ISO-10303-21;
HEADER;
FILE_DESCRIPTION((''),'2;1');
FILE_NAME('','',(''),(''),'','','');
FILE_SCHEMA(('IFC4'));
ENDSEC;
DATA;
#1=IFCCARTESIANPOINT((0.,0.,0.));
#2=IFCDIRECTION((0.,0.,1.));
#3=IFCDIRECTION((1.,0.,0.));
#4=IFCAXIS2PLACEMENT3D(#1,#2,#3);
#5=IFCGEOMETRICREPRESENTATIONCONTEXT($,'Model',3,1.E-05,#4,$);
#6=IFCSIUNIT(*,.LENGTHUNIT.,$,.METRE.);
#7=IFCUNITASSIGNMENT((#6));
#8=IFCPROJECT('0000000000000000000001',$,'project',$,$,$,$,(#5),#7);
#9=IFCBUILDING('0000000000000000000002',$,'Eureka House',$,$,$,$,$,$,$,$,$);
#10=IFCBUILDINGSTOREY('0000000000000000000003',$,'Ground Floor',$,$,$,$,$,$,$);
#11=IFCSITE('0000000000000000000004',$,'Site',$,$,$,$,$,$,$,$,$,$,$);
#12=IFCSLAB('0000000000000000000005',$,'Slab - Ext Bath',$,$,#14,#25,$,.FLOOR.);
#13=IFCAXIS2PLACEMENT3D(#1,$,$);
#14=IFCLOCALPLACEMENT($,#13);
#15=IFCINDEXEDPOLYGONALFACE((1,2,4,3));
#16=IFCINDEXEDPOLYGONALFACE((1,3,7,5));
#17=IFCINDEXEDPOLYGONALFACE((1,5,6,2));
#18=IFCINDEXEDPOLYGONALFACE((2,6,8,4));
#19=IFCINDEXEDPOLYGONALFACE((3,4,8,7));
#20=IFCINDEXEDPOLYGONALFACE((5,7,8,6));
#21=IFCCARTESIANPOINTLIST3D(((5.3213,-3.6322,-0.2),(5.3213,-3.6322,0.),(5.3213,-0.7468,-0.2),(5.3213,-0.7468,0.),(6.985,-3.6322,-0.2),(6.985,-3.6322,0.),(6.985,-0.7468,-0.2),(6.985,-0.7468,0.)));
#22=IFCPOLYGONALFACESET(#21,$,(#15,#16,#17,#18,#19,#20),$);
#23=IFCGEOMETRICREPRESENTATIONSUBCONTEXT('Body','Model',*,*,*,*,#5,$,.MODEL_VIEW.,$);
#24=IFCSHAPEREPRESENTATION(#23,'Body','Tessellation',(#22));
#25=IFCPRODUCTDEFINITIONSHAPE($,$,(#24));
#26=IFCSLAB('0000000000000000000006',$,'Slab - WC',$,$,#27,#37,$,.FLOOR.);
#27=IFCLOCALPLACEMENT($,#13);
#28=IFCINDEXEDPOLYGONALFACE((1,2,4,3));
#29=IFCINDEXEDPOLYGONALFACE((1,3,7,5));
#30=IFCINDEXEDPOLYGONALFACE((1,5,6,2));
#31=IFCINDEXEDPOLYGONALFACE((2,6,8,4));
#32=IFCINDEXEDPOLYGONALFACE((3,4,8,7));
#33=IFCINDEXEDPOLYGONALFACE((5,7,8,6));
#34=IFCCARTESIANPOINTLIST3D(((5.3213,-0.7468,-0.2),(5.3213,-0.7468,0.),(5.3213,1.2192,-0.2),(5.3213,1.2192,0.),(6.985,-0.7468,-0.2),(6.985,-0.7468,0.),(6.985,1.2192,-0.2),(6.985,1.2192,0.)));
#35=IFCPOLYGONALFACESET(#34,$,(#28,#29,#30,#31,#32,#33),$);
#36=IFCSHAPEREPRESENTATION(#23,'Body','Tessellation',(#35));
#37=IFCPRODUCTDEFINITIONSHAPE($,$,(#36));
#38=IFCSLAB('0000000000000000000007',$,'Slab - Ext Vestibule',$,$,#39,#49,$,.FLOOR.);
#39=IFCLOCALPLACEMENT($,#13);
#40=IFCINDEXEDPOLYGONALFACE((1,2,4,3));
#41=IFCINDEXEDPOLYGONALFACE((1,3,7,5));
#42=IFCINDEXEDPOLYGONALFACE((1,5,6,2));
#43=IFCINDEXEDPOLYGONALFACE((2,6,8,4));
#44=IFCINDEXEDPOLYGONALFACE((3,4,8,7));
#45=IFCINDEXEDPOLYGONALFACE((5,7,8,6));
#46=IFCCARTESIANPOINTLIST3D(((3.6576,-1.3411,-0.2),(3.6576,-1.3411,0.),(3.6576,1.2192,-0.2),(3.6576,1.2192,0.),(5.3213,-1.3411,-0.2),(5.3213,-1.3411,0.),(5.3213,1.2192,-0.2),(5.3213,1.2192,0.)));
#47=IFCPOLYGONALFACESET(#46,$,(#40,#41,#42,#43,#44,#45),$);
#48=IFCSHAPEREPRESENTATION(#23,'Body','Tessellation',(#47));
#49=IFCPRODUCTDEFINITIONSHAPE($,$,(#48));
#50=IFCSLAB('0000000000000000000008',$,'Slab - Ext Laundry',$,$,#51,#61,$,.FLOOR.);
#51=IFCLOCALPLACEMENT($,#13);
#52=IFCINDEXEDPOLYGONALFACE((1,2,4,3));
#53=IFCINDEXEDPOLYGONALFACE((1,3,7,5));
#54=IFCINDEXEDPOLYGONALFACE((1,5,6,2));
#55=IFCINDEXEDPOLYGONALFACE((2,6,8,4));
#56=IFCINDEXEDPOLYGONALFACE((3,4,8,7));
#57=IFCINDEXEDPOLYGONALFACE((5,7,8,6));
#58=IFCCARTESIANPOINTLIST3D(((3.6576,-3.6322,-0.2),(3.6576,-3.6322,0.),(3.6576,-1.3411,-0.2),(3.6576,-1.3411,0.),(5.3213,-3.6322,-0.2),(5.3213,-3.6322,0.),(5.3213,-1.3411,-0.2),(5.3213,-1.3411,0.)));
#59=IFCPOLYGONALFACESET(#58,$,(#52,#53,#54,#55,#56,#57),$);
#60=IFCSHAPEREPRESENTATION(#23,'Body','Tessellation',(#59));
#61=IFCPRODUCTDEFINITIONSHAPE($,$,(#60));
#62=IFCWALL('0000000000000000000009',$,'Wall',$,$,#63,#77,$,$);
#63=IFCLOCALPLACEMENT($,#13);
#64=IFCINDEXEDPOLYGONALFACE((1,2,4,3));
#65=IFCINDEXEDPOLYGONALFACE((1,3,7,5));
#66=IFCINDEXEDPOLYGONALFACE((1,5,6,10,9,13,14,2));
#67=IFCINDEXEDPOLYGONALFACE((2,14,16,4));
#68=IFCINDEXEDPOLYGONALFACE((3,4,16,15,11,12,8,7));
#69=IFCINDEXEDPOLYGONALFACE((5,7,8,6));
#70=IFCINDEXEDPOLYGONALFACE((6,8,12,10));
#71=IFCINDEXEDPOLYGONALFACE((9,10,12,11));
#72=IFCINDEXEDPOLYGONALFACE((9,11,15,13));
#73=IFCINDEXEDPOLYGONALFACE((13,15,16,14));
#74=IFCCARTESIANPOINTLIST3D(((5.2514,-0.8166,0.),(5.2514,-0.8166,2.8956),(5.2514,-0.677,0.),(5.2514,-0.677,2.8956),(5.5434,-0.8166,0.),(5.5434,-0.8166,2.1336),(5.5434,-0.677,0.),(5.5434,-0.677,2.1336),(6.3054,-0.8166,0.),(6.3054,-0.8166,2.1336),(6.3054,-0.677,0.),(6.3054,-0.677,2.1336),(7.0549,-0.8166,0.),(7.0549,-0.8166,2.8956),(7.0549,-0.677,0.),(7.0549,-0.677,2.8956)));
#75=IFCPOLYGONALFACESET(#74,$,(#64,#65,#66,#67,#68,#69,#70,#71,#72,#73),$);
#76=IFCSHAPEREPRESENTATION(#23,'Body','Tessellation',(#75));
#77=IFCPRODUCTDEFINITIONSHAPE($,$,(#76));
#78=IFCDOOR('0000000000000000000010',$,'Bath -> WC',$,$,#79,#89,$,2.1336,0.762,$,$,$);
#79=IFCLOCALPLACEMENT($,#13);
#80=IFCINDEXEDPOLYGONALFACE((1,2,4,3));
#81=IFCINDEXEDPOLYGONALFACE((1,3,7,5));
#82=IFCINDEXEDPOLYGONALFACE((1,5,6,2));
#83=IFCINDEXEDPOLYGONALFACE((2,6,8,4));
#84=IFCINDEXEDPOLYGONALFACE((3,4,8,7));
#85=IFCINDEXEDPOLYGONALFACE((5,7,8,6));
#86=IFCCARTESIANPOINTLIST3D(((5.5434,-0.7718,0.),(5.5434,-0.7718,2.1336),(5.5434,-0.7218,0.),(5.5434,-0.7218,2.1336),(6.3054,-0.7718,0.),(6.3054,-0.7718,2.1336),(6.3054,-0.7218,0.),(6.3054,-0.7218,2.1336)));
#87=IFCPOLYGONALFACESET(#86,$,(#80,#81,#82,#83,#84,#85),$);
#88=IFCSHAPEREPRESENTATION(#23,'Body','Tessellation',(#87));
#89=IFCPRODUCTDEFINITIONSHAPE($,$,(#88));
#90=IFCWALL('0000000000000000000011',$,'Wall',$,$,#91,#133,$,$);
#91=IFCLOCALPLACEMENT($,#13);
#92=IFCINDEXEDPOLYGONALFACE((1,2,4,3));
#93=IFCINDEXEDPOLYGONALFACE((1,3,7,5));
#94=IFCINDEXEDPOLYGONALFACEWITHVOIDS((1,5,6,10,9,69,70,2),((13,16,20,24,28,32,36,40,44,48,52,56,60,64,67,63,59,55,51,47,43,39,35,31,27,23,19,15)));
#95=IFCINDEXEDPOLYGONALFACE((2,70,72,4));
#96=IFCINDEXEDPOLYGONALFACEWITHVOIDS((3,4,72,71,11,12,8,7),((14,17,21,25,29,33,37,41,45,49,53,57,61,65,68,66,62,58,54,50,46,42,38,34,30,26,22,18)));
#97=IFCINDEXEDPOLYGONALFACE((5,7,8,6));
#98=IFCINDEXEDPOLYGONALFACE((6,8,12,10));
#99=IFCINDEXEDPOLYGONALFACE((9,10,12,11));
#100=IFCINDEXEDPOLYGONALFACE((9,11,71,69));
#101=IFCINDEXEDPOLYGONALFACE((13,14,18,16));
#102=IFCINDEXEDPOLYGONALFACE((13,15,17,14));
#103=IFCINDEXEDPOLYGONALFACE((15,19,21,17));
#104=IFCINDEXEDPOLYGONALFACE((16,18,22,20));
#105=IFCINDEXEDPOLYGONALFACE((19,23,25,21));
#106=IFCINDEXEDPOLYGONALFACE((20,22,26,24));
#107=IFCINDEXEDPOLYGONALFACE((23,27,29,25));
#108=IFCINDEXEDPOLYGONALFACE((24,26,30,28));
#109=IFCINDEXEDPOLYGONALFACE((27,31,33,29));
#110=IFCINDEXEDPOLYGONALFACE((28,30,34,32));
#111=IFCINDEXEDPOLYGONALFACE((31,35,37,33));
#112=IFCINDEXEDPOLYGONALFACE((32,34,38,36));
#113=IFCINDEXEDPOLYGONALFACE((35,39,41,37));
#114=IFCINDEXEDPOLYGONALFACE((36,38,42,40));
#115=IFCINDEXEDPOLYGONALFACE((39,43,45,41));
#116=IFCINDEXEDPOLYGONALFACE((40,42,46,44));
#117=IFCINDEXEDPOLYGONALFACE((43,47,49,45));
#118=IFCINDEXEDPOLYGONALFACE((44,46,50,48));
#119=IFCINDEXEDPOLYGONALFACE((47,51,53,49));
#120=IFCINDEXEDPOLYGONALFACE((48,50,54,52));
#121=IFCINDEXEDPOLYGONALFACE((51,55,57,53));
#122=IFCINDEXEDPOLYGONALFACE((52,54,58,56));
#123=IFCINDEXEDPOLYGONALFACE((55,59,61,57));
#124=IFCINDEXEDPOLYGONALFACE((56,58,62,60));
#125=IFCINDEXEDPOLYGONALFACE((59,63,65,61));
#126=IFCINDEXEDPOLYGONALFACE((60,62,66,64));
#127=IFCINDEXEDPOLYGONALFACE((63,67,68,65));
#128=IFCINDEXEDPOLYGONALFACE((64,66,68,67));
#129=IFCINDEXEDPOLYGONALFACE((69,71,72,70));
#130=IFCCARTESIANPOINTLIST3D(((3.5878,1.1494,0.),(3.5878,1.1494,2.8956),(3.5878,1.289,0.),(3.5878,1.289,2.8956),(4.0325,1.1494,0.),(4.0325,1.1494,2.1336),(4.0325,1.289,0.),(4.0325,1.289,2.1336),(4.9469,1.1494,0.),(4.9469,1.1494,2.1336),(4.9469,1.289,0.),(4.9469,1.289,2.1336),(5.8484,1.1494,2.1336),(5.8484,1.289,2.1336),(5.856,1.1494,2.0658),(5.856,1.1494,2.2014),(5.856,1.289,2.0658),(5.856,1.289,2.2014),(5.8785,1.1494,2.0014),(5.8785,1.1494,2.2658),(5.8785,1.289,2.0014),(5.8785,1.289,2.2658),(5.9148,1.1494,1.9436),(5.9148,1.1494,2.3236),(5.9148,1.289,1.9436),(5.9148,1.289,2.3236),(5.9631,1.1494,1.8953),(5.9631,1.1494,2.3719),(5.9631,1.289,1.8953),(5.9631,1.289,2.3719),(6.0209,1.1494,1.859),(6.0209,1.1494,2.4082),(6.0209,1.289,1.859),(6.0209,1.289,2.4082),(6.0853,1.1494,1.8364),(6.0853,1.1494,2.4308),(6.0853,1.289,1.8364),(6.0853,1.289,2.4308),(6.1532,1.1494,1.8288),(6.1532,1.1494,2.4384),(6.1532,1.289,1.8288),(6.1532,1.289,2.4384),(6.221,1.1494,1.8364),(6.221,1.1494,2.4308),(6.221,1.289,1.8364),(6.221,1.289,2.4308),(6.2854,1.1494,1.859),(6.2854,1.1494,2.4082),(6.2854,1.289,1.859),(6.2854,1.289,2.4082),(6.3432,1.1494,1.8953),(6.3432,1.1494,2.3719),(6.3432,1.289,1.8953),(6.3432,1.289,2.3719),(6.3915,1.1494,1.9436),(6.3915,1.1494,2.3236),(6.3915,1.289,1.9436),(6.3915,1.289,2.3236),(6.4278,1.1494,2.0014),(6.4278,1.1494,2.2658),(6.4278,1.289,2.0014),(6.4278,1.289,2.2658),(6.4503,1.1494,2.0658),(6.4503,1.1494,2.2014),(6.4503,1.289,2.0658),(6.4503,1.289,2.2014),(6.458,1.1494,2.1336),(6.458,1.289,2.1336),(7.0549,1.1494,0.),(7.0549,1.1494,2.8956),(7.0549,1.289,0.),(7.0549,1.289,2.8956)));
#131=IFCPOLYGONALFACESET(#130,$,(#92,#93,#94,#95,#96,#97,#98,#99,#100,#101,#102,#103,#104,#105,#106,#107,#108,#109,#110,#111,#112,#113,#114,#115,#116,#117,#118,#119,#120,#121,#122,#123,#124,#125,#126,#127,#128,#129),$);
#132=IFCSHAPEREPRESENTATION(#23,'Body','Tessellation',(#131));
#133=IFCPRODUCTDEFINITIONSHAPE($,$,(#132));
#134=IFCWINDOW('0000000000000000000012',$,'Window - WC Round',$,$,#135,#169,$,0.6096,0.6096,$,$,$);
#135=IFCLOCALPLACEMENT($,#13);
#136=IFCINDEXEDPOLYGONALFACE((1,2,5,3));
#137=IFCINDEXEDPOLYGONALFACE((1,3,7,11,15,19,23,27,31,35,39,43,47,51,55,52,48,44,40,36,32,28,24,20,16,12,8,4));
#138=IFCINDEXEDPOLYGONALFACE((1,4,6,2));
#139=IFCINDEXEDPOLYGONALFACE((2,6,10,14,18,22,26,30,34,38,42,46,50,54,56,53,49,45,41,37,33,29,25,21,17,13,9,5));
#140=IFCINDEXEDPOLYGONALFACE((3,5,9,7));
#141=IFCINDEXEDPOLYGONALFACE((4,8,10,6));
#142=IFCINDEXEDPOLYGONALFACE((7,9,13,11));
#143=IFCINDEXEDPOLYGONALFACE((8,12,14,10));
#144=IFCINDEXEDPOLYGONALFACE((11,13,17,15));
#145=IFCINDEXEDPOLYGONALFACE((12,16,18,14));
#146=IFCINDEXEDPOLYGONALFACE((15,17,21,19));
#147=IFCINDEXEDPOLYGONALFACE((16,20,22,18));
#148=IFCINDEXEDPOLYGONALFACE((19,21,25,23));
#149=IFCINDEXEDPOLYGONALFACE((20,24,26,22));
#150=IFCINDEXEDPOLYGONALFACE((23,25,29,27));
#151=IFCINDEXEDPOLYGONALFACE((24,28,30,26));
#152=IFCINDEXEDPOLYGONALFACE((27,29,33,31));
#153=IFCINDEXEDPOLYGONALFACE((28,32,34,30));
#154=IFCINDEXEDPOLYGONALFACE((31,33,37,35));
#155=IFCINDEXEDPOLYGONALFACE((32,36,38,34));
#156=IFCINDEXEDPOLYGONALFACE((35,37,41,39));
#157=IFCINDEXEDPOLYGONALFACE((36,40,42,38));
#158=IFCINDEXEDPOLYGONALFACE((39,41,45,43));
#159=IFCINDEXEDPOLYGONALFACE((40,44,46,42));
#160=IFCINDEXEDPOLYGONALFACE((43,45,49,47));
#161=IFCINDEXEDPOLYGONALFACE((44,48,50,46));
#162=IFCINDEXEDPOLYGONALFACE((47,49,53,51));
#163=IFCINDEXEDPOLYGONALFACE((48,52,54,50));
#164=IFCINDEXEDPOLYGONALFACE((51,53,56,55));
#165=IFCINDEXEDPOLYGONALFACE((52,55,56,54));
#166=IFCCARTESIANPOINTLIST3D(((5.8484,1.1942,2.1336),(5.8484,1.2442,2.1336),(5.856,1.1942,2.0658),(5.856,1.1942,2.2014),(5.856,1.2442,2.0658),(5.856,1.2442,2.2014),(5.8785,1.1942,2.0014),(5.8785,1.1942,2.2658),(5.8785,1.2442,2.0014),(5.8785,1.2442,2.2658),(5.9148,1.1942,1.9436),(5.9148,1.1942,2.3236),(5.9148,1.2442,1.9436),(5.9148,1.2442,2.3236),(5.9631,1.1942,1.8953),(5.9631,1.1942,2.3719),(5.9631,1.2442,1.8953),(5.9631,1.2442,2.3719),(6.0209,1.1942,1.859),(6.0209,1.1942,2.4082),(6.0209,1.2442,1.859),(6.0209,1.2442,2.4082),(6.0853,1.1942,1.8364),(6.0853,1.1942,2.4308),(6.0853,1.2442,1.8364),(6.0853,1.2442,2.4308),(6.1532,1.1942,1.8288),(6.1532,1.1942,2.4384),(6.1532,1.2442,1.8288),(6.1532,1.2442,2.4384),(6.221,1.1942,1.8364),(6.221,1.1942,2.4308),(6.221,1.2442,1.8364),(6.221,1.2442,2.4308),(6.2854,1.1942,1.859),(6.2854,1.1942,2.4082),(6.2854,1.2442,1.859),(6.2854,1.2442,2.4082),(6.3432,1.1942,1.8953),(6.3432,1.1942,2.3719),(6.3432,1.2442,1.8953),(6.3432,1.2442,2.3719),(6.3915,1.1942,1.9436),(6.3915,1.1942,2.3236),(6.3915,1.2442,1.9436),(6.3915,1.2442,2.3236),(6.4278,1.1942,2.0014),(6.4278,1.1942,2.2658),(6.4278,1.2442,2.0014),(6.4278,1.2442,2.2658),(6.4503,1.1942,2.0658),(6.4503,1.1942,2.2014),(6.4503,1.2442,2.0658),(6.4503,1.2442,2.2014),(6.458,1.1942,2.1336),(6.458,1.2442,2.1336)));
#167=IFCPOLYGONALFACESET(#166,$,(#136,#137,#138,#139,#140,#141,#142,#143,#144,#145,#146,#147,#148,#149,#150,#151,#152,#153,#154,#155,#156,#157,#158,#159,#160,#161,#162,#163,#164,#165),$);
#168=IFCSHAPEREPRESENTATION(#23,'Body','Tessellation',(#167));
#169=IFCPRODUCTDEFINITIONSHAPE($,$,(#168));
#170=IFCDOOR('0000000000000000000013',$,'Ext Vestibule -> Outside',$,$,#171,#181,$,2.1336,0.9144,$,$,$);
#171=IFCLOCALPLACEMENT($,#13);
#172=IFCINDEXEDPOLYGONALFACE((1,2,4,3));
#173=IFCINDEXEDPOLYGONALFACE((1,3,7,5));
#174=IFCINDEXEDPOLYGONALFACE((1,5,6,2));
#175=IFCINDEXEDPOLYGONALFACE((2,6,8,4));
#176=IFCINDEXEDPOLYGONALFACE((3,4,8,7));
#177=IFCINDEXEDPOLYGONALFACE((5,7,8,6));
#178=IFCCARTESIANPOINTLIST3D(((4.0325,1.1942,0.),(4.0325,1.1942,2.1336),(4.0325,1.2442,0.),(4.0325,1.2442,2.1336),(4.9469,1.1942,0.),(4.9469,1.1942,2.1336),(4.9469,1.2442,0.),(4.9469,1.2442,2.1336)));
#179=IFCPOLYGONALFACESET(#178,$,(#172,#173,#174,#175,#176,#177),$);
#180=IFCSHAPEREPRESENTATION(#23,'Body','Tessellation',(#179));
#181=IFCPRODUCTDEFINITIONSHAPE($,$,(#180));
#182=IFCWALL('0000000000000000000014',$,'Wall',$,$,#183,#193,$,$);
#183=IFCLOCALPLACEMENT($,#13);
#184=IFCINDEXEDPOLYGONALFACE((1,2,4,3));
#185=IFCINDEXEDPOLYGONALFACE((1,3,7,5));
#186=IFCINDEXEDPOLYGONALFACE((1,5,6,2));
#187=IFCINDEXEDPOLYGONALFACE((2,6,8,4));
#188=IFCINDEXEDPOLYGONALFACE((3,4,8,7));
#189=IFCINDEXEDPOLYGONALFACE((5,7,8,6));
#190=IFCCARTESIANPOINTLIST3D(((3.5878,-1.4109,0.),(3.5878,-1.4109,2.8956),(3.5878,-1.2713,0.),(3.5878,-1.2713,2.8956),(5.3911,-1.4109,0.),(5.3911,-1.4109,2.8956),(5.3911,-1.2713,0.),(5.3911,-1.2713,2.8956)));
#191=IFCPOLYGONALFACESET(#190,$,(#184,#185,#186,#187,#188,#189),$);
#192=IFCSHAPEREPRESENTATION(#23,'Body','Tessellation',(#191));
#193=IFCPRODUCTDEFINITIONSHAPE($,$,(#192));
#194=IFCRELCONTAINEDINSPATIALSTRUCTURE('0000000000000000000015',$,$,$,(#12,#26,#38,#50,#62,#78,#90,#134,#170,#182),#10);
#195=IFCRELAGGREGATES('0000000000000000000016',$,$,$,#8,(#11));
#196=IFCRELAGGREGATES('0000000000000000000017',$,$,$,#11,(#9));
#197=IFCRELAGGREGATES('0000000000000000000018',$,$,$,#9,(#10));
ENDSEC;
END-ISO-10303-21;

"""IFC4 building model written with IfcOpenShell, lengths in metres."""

from ifc_helpers import new_model, si_unit, frame, origin, origin_with_axes, origin_2d, place, context, subcontext, project, spatial, rectangle, circle, extrude, element, fill, save


model = new_model("IFC4")

# Units and contexts
model_context = context("Model", 3, precision=1e-05, world=origin_with_axes())
body_context = subcontext(model_context, "Body", "Model", "MODEL_VIEW")
ifc_project = project(units=[si_unit("LENGTHUNIT", "METRE")], contexts=[model_context])

# Site, building, storey
site = spatial("IfcSite", under=ifc_project, Name="Site")
building = spatial("IfcBuilding", under=site, Name="Eureka House")
storey = spatial("IfcBuildingStorey", under=building, Name="Ground Floor")

# Slabs
slab_1_placement = place(None, frame((6.1532, -2.1895, -0.2), z_axis=(0.0, 0.0, 1.0), x_axis=(1.0, 0.0, 0.0)))
element("IfcSlab", 1, at=slab_1_placement, inside=storey, Name="Slab - Ext Bath", PredefinedType="FLOOR", context=body_context, shape_type="SweptSolid", body=[
    extrude(rectangle(XDim=1.6637, YDim=2.8855, at=origin_2d()), origin(), (0.0, 0.0, 1.0), 0.2),
])
slab_2_placement = place(None, frame((6.1532, 0.2362, -0.2), z_axis=(0.0, 0.0, 1.0), x_axis=(1.0, 0.0, 0.0)))
element("IfcSlab", 2, at=slab_2_placement, inside=storey, Name="Slab - WC", PredefinedType="FLOOR", context=body_context, shape_type="SweptSolid", body=[
    extrude(rectangle(XDim=1.6637, YDim=1.966, at=origin_2d()), origin(), (0.0, 0.0, 1.0), 0.2),
])
slab_3_placement = place(None, frame((4.4894, -0.061, -0.2), z_axis=(0.0, 0.0, 1.0), x_axis=(1.0, 0.0, 0.0)))
element("IfcSlab", 3, at=slab_3_placement, inside=storey, Name="Slab - Ext Vestibule", PredefinedType="FLOOR", context=body_context, shape_type="SweptSolid", body=[
    extrude(rectangle(XDim=1.6637, YDim=2.5603, at=origin_2d()), origin(), (0.0, 0.0, 1.0), 0.2),
])
slab_4_placement = place(None, frame((4.4894, -2.4867, -0.2), z_axis=(0.0, 0.0, 1.0), x_axis=(1.0, 0.0, 0.0)))
element("IfcSlab", 4, at=slab_4_placement, inside=storey, Name="Slab - Ext Laundry", PredefinedType="FLOOR", context=body_context, shape_type="SweptSolid", body=[
    extrude(rectangle(XDim=1.6637, YDim=2.2911, at=origin_2d()), origin(), (0.0, 0.0, 1.0), 0.2),
])

# Wall, opening, door
wall_1_placement = place(None, frame((6.1532, -0.7468, 0.0), z_axis=(0.0, 0.0, 1.0), x_axis=(1.0, 0.0, 0.0)))
wall_1 = element("IfcWall", 5, at=wall_1_placement, inside=storey, Name="Wall", context=body_context, shape_type="SweptSolid", body=[
    extrude(rectangle(XDim=1.8034, YDim=0.1397, at=origin_2d()), origin(), (0.0, 0.0, 1.0), 2.8956),
])
opening_1_placement = place(wall_1_placement, frame((-0.2288, 0.0, 0.0), z_axis=(0.0, 0.0, 1.0), x_axis=(1.0, 0.0, 0.0)))
opening_1 = element("IfcOpeningElement", 6, at=opening_1_placement, cuts=wall_1, context=body_context, shape_type="SweptSolid", body=[
    extrude(rectangle(XDim=0.762, YDim=0.2397, at=origin_2d()), origin(), (0.0, 0.0, 1.0), 2.1336),
])
door_1_placement = place(opening_1_placement, origin_with_axes())
door_1 = element("IfcDoor", 7, at=door_1_placement, inside=storey, Name="Bath -> WC", OverallHeight=2.1336, OverallWidth=0.762, context=body_context, shape_type="SweptSolid", body=[
    extrude(rectangle(XDim=0.762, YDim=0.05, at=origin_2d()), origin(), (0.0, 0.0, 1.0), 2.1336),
])
fill(opening_1, door_1)

# Wall, openings, window, door
wall_2_placement = place(None, frame((5.3213, 1.2192, 0.0), z_axis=(0.0, 0.0, 1.0), x_axis=(1.0, 0.0, 0.0)))
wall_2 = element("IfcWall", 8, at=wall_2_placement, inside=storey, Name="Wall", context=body_context, shape_type="SweptSolid", body=[
    extrude(rectangle(XDim=3.4671, YDim=0.1397, at=origin_2d()), origin(), (0.0, 0.0, 1.0), 2.8956),
])
opening_2_placement = place(wall_2_placement, frame((-5.3213, -1.2192, 0.0), z_axis=(0.0, 0.0, 1.0), x_axis=(1.0, 0.0, 0.0)))
opening_2 = element("IfcOpeningElement", 9, at=opening_2_placement, cuts=wall_2, context=body_context, shape_type="SweptSolid", body=[
    extrude(circle(Radius=0.3048), frame((6.1532, 1.0994, 2.1336), z_axis=(0.0, 1.0, 0.0), x_axis=(1.0, 0.0, 0.0)), (0.0, 0.0, 1.0), 0.2397),
])
opening_3_placement = place(wall_2_placement, frame((-0.8316, 0.0, 0.0), z_axis=(0.0, 0.0, 1.0), x_axis=(1.0, 0.0, 0.0)))
opening_3 = element("IfcOpeningElement", 10, at=opening_3_placement, cuts=wall_2, context=body_context, shape_type="SweptSolid", body=[
    extrude(rectangle(XDim=0.9144, YDim=0.2397, at=origin_2d()), origin(), (0.0, 0.0, 1.0), 2.1336),
])
window_1_placement = place(opening_2_placement, origin_with_axes())
window_1 = element("IfcWindow", 11, at=window_1_placement, inside=storey, Name="Window - WC Round", OverallHeight=0.6096, OverallWidth=0.6096, context=body_context, shape_type="SweptSolid", body=[
    extrude(circle(Radius=0.3048), frame((6.1532, 1.1942, 2.1336), z_axis=(0.0, 1.0, 0.0), x_axis=(1.0, 0.0, 0.0)), (0.0, 0.0, 1.0), 0.05),
])
fill(opening_2, window_1)
door_2_placement = place(opening_3_placement, origin_with_axes())
door_2 = element("IfcDoor", 12, at=door_2_placement, inside=storey, Name="Ext Vestibule -> Outside", OverallHeight=2.1336, OverallWidth=0.9144, context=body_context, shape_type="SweptSolid", body=[
    extrude(rectangle(XDim=0.9144, YDim=0.05, at=origin_2d()), origin(), (0.0, 0.0, 1.0), 2.1336),
])
fill(opening_3, door_2)

# Wall
wall_3_placement = place(None, frame((4.4894, -1.3411, 0.0), z_axis=(0.0, 0.0, 1.0), x_axis=(1.0, 0.0, 0.0)))
element("IfcWall", 13, at=wall_3_placement, inside=storey, Name="Wall", context=body_context, shape_type="SweptSolid", body=[
    extrude(rectangle(XDim=1.8034, YDim=0.1397, at=origin_2d()), origin(), (0.0, 0.0, 1.0), 2.8956),
])

save(model, "model.ifc")
